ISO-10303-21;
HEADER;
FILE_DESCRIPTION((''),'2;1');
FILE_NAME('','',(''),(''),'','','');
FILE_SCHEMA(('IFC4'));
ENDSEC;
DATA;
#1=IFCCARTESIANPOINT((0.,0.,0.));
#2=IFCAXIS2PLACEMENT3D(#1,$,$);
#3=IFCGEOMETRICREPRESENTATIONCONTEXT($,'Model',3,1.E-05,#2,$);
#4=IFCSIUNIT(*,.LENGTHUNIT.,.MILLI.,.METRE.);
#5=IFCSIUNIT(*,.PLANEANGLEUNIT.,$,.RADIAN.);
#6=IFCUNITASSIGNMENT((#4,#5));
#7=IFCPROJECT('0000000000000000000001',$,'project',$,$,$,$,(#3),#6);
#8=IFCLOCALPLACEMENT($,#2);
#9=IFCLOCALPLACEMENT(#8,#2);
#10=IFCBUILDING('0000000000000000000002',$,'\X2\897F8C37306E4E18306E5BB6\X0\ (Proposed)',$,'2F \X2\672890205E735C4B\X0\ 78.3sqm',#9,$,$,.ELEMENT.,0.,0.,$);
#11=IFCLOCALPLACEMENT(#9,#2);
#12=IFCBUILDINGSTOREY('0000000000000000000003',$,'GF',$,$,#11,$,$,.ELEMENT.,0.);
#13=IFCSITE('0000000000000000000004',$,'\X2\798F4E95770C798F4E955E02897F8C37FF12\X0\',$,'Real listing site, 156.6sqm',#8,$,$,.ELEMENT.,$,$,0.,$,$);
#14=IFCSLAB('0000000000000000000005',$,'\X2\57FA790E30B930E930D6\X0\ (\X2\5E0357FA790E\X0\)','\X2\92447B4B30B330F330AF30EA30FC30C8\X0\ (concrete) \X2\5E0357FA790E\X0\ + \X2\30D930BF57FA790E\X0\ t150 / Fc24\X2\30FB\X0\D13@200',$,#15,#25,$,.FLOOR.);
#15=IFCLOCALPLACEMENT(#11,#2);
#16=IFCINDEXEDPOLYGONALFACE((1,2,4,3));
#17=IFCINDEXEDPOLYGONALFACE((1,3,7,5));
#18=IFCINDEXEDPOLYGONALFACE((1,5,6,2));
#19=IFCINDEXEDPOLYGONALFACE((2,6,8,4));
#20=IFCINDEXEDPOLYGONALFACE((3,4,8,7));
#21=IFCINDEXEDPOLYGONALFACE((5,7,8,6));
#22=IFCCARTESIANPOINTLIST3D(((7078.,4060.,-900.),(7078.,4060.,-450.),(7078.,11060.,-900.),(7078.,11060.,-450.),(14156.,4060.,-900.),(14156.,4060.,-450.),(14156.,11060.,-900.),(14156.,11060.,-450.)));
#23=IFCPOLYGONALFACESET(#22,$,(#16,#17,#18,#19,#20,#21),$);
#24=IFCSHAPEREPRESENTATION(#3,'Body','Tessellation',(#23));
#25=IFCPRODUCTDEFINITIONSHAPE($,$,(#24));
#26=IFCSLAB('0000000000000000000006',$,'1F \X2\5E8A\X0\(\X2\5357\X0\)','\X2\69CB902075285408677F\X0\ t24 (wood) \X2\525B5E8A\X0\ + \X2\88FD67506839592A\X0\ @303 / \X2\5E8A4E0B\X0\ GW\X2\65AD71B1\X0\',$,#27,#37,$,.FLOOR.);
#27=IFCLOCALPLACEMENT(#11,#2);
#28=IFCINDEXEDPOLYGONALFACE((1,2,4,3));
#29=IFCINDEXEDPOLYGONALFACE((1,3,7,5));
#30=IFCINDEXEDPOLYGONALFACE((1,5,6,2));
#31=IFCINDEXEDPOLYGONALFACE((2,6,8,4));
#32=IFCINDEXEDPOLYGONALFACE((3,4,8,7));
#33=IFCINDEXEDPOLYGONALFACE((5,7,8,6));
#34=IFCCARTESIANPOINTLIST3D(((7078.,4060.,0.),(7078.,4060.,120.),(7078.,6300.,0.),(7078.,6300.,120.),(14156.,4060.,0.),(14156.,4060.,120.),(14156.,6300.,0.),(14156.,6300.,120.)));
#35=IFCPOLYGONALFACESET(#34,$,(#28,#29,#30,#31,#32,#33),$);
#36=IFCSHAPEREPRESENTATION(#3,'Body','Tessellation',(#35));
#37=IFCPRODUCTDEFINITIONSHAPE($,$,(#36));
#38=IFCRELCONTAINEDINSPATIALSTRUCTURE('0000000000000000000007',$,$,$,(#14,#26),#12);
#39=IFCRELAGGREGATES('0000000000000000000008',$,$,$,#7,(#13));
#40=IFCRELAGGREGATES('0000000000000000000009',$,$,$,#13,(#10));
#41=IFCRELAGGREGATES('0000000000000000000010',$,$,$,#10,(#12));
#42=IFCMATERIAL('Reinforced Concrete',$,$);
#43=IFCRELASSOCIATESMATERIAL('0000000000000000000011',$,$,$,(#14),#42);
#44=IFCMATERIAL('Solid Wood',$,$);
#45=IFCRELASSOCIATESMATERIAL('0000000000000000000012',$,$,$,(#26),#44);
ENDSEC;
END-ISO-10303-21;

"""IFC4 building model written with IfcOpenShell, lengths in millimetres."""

from ifc_helpers import new_model, si_unit, frame, frame_2d, origin, place, context, project, spatial, rectangle, extrude, material, element, save


model = new_model("IFC4")

# Units and contexts
model_context = context("Model", 3, precision=1e-05, world=origin())
ifc_project = project(units=[si_unit("LENGTHUNIT", "METRE", prefix="MILLI"), si_unit("PLANEANGLEUNIT", "RADIAN")], contexts=[model_context])

# Site, building, storey
site_placement = place(None, origin())
site = spatial("IfcSite", under=ifc_project, at=site_placement, Name="福井県福井市西谷２", ObjectType="Real listing site, 156.6sqm", CompositionType="ELEMENT", RefElevation=0.0)
building_placement = place(site_placement, origin())
building = spatial("IfcBuilding", under=site, at=building_placement, Name="西谷の丘の家 (Proposed)", ObjectType="2F 木造平屋 78.3sqm", CompositionType="ELEMENT", ElevationOfRefHeight=0.0, ElevationOfTerrain=0.0)
storey_placement = place(building_placement, origin())
storey = spatial("IfcBuildingStorey", under=building, at=storey_placement, Name="GF", CompositionType="ELEMENT", Elevation=0.0)

# Slabs
ifc_material_1 = material(Name="Reinforced Concrete")
slab_1_placement = place(storey_placement, frame((3539.0, 2030.0, -450.0)))
element("IfcSlab", 1, at=slab_1_placement, inside=storey, material=ifc_material_1, Name="基礎スラブ (布基礎)", Description="鉄筋コンクリート (concrete) 布基礎 + ベタ基礎 t150 / Fc24・D13@200", PredefinedType="FLOOR", context=model_context, shape_type="SweptSolid", body=[
    extrude(rectangle(XDim=7078.0, YDim=7000.0, at=frame_2d((3539.0, 3500.0))), frame((3539.0, 2030.0, -450.0)), (0.0, 0.0, 1.0), 450.0),
])
ifc_material_2 = material(Name="Solid Wood")
slab_2_placement = place(storey_placement, frame((3539.0, 2030.0, 0.0)))
element("IfcSlab", 2, at=slab_2_placement, inside=storey, material=ifc_material_2, Name="1F 床(南)", Description="構造用合板 t24 (wood) 剛床 + 製材根太 @303 / 床下 GW断熱", PredefinedType="FLOOR", context=model_context, shape_type="SweptSolid", body=[
    extrude(rectangle(XDim=7078.0, YDim=2240.0, at=frame_2d((3539.0, 1120.0))), frame((3539.0, 2030.0, 0.0)), (0.0, 0.0, 1.0), 120.0),
])

save(model, "model.ifc")
